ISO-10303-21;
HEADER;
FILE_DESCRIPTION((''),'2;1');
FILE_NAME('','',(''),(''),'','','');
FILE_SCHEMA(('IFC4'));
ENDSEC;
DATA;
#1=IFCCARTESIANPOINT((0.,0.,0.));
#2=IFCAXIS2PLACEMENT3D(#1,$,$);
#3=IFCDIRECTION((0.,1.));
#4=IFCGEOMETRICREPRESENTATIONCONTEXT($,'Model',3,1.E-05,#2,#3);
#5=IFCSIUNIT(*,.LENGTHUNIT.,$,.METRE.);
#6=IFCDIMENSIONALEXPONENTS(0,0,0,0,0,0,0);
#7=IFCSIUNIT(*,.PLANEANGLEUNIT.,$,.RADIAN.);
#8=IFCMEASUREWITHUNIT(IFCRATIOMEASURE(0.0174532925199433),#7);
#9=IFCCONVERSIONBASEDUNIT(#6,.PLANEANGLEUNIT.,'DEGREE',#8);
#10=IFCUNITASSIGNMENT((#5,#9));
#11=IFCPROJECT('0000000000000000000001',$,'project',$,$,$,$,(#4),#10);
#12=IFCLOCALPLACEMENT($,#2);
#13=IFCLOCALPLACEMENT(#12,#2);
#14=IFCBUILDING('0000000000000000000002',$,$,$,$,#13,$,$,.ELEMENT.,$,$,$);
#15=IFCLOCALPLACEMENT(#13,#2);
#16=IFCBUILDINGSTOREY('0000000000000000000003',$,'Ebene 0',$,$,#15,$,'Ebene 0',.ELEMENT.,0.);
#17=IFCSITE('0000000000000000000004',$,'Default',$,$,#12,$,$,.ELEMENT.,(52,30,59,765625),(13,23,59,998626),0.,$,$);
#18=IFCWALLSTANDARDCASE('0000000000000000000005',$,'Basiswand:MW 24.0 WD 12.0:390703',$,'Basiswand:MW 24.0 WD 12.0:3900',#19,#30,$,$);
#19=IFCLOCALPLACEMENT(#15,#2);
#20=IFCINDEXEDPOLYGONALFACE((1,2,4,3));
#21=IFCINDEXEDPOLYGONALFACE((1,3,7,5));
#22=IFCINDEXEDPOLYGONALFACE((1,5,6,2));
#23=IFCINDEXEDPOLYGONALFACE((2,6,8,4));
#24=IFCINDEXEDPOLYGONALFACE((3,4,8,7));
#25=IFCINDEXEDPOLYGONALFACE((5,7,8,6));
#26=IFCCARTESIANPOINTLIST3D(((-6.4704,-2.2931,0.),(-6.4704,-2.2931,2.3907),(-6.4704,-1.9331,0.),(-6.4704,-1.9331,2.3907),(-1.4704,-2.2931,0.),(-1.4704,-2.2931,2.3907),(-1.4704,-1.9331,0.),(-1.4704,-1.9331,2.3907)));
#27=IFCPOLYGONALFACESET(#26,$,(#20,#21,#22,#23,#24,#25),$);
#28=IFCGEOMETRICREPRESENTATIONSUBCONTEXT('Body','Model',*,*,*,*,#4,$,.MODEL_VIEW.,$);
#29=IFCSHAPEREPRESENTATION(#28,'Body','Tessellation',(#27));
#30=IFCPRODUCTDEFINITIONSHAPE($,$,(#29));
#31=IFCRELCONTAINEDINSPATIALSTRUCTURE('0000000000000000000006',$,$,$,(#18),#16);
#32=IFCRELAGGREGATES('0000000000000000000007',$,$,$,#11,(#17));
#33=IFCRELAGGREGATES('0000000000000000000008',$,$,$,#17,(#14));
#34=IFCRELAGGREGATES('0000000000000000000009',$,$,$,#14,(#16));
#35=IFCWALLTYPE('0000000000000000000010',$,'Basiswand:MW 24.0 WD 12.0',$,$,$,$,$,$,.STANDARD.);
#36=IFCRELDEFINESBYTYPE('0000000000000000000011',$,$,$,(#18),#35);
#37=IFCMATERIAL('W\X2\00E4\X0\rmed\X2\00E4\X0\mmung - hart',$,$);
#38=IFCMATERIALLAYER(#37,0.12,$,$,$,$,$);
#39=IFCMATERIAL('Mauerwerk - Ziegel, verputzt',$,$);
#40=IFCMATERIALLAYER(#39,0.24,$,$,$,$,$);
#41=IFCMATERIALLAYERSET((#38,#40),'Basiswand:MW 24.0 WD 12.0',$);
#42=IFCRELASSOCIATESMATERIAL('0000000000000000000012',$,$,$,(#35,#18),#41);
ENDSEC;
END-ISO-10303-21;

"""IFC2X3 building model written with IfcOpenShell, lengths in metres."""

from ifc_helpers import new_model, entity, si_unit, converted_unit, direction, frame, frame_2d, origin, place, context, subcontext, project, spatial, rectangle, extrude, material, layer, layer_set, layer_usage, type_object, element, save


model = new_model("IFC2X3")

# Units and contexts
model_context = context("Model", 3, precision=1e-05, world=origin(), true_north=direction((0.0, 1.0)))
body_context = subcontext(model_context, "Body", "Model", "MODEL_VIEW")
ifc_project = project(units=[si_unit("LENGTHUNIT", "METRE"), converted_unit("PLANEANGLEUNIT", "DEGREE", entity("IfcRatioMeasure", 0.0174532925199433), si_unit("PLANEANGLEUNIT", "RADIAN"), dimensions=[0, 0, 0, 0, 0, 0, 0])], contexts=[model_context])

# Site, building, storey
site_placement = place(None, origin())
site = spatial("IfcSite", under=ifc_project, at=site_placement, Name="Default", CompositionType="ELEMENT", RefLatitude=(52, 30, 59, 765625), RefLongitude=(13, 23, 59, 998626), RefElevation=0.0)
building_placement = place(site_placement, origin())
building = spatial("IfcBuilding", under=site, at=building_placement, CompositionType="ELEMENT")
storey_placement = place(building_placement, origin())
storey = spatial("IfcBuildingStorey", under=building, at=storey_placement, Name="Ebene 0", LongName="Ebene 0", CompositionType="ELEMENT", Elevation=0.0)

# Wall
ifc_material_1 = material(Name="Wärmedämmung - hart")
ifc_layer_1 = layer(ifc_material_1, 0.12)
ifc_material_2 = material(Name="Mauerwerk - Ziegel, verputzt")
ifc_layer_2 = layer(ifc_material_2, 0.24)
ifc_layer_set = layer_set([ifc_layer_1, ifc_layer_2], Name="Basiswand:MW 24.0 WD 12.0")
ifc_layer_usage = layer_usage(ifc_layer_set, "AXIS2", "NEGATIVE", 0.18)
wall_type = type_object("IfcWallType", Name="Basiswand:MW 24.0 WD 12.0", PredefinedType="STANDARD", material=ifc_layer_set)
wall_placement = place(storey_placement, frame((-6.4704, -2.1131, 0.0)))
element("IfcWallStandardCase", 1, at=wall_placement, inside=storey, type_object=wall_type, material=ifc_layer_usage, Name="Basiswand:MW 24.0 WD 12.0:390703", ObjectType="Basiswand:MW 24.0 WD 12.0:3900", context=body_context, shape_type="SweptSolid", body=[
    extrude(rectangle(XDim=5.0, YDim=0.36, at=frame_2d((2.5, 0.0), x_axis=(-1.0, 0.0))), origin(), (0.0, 0.0, 1.0), 2.3907),
])

save(model, "model.ifc")
